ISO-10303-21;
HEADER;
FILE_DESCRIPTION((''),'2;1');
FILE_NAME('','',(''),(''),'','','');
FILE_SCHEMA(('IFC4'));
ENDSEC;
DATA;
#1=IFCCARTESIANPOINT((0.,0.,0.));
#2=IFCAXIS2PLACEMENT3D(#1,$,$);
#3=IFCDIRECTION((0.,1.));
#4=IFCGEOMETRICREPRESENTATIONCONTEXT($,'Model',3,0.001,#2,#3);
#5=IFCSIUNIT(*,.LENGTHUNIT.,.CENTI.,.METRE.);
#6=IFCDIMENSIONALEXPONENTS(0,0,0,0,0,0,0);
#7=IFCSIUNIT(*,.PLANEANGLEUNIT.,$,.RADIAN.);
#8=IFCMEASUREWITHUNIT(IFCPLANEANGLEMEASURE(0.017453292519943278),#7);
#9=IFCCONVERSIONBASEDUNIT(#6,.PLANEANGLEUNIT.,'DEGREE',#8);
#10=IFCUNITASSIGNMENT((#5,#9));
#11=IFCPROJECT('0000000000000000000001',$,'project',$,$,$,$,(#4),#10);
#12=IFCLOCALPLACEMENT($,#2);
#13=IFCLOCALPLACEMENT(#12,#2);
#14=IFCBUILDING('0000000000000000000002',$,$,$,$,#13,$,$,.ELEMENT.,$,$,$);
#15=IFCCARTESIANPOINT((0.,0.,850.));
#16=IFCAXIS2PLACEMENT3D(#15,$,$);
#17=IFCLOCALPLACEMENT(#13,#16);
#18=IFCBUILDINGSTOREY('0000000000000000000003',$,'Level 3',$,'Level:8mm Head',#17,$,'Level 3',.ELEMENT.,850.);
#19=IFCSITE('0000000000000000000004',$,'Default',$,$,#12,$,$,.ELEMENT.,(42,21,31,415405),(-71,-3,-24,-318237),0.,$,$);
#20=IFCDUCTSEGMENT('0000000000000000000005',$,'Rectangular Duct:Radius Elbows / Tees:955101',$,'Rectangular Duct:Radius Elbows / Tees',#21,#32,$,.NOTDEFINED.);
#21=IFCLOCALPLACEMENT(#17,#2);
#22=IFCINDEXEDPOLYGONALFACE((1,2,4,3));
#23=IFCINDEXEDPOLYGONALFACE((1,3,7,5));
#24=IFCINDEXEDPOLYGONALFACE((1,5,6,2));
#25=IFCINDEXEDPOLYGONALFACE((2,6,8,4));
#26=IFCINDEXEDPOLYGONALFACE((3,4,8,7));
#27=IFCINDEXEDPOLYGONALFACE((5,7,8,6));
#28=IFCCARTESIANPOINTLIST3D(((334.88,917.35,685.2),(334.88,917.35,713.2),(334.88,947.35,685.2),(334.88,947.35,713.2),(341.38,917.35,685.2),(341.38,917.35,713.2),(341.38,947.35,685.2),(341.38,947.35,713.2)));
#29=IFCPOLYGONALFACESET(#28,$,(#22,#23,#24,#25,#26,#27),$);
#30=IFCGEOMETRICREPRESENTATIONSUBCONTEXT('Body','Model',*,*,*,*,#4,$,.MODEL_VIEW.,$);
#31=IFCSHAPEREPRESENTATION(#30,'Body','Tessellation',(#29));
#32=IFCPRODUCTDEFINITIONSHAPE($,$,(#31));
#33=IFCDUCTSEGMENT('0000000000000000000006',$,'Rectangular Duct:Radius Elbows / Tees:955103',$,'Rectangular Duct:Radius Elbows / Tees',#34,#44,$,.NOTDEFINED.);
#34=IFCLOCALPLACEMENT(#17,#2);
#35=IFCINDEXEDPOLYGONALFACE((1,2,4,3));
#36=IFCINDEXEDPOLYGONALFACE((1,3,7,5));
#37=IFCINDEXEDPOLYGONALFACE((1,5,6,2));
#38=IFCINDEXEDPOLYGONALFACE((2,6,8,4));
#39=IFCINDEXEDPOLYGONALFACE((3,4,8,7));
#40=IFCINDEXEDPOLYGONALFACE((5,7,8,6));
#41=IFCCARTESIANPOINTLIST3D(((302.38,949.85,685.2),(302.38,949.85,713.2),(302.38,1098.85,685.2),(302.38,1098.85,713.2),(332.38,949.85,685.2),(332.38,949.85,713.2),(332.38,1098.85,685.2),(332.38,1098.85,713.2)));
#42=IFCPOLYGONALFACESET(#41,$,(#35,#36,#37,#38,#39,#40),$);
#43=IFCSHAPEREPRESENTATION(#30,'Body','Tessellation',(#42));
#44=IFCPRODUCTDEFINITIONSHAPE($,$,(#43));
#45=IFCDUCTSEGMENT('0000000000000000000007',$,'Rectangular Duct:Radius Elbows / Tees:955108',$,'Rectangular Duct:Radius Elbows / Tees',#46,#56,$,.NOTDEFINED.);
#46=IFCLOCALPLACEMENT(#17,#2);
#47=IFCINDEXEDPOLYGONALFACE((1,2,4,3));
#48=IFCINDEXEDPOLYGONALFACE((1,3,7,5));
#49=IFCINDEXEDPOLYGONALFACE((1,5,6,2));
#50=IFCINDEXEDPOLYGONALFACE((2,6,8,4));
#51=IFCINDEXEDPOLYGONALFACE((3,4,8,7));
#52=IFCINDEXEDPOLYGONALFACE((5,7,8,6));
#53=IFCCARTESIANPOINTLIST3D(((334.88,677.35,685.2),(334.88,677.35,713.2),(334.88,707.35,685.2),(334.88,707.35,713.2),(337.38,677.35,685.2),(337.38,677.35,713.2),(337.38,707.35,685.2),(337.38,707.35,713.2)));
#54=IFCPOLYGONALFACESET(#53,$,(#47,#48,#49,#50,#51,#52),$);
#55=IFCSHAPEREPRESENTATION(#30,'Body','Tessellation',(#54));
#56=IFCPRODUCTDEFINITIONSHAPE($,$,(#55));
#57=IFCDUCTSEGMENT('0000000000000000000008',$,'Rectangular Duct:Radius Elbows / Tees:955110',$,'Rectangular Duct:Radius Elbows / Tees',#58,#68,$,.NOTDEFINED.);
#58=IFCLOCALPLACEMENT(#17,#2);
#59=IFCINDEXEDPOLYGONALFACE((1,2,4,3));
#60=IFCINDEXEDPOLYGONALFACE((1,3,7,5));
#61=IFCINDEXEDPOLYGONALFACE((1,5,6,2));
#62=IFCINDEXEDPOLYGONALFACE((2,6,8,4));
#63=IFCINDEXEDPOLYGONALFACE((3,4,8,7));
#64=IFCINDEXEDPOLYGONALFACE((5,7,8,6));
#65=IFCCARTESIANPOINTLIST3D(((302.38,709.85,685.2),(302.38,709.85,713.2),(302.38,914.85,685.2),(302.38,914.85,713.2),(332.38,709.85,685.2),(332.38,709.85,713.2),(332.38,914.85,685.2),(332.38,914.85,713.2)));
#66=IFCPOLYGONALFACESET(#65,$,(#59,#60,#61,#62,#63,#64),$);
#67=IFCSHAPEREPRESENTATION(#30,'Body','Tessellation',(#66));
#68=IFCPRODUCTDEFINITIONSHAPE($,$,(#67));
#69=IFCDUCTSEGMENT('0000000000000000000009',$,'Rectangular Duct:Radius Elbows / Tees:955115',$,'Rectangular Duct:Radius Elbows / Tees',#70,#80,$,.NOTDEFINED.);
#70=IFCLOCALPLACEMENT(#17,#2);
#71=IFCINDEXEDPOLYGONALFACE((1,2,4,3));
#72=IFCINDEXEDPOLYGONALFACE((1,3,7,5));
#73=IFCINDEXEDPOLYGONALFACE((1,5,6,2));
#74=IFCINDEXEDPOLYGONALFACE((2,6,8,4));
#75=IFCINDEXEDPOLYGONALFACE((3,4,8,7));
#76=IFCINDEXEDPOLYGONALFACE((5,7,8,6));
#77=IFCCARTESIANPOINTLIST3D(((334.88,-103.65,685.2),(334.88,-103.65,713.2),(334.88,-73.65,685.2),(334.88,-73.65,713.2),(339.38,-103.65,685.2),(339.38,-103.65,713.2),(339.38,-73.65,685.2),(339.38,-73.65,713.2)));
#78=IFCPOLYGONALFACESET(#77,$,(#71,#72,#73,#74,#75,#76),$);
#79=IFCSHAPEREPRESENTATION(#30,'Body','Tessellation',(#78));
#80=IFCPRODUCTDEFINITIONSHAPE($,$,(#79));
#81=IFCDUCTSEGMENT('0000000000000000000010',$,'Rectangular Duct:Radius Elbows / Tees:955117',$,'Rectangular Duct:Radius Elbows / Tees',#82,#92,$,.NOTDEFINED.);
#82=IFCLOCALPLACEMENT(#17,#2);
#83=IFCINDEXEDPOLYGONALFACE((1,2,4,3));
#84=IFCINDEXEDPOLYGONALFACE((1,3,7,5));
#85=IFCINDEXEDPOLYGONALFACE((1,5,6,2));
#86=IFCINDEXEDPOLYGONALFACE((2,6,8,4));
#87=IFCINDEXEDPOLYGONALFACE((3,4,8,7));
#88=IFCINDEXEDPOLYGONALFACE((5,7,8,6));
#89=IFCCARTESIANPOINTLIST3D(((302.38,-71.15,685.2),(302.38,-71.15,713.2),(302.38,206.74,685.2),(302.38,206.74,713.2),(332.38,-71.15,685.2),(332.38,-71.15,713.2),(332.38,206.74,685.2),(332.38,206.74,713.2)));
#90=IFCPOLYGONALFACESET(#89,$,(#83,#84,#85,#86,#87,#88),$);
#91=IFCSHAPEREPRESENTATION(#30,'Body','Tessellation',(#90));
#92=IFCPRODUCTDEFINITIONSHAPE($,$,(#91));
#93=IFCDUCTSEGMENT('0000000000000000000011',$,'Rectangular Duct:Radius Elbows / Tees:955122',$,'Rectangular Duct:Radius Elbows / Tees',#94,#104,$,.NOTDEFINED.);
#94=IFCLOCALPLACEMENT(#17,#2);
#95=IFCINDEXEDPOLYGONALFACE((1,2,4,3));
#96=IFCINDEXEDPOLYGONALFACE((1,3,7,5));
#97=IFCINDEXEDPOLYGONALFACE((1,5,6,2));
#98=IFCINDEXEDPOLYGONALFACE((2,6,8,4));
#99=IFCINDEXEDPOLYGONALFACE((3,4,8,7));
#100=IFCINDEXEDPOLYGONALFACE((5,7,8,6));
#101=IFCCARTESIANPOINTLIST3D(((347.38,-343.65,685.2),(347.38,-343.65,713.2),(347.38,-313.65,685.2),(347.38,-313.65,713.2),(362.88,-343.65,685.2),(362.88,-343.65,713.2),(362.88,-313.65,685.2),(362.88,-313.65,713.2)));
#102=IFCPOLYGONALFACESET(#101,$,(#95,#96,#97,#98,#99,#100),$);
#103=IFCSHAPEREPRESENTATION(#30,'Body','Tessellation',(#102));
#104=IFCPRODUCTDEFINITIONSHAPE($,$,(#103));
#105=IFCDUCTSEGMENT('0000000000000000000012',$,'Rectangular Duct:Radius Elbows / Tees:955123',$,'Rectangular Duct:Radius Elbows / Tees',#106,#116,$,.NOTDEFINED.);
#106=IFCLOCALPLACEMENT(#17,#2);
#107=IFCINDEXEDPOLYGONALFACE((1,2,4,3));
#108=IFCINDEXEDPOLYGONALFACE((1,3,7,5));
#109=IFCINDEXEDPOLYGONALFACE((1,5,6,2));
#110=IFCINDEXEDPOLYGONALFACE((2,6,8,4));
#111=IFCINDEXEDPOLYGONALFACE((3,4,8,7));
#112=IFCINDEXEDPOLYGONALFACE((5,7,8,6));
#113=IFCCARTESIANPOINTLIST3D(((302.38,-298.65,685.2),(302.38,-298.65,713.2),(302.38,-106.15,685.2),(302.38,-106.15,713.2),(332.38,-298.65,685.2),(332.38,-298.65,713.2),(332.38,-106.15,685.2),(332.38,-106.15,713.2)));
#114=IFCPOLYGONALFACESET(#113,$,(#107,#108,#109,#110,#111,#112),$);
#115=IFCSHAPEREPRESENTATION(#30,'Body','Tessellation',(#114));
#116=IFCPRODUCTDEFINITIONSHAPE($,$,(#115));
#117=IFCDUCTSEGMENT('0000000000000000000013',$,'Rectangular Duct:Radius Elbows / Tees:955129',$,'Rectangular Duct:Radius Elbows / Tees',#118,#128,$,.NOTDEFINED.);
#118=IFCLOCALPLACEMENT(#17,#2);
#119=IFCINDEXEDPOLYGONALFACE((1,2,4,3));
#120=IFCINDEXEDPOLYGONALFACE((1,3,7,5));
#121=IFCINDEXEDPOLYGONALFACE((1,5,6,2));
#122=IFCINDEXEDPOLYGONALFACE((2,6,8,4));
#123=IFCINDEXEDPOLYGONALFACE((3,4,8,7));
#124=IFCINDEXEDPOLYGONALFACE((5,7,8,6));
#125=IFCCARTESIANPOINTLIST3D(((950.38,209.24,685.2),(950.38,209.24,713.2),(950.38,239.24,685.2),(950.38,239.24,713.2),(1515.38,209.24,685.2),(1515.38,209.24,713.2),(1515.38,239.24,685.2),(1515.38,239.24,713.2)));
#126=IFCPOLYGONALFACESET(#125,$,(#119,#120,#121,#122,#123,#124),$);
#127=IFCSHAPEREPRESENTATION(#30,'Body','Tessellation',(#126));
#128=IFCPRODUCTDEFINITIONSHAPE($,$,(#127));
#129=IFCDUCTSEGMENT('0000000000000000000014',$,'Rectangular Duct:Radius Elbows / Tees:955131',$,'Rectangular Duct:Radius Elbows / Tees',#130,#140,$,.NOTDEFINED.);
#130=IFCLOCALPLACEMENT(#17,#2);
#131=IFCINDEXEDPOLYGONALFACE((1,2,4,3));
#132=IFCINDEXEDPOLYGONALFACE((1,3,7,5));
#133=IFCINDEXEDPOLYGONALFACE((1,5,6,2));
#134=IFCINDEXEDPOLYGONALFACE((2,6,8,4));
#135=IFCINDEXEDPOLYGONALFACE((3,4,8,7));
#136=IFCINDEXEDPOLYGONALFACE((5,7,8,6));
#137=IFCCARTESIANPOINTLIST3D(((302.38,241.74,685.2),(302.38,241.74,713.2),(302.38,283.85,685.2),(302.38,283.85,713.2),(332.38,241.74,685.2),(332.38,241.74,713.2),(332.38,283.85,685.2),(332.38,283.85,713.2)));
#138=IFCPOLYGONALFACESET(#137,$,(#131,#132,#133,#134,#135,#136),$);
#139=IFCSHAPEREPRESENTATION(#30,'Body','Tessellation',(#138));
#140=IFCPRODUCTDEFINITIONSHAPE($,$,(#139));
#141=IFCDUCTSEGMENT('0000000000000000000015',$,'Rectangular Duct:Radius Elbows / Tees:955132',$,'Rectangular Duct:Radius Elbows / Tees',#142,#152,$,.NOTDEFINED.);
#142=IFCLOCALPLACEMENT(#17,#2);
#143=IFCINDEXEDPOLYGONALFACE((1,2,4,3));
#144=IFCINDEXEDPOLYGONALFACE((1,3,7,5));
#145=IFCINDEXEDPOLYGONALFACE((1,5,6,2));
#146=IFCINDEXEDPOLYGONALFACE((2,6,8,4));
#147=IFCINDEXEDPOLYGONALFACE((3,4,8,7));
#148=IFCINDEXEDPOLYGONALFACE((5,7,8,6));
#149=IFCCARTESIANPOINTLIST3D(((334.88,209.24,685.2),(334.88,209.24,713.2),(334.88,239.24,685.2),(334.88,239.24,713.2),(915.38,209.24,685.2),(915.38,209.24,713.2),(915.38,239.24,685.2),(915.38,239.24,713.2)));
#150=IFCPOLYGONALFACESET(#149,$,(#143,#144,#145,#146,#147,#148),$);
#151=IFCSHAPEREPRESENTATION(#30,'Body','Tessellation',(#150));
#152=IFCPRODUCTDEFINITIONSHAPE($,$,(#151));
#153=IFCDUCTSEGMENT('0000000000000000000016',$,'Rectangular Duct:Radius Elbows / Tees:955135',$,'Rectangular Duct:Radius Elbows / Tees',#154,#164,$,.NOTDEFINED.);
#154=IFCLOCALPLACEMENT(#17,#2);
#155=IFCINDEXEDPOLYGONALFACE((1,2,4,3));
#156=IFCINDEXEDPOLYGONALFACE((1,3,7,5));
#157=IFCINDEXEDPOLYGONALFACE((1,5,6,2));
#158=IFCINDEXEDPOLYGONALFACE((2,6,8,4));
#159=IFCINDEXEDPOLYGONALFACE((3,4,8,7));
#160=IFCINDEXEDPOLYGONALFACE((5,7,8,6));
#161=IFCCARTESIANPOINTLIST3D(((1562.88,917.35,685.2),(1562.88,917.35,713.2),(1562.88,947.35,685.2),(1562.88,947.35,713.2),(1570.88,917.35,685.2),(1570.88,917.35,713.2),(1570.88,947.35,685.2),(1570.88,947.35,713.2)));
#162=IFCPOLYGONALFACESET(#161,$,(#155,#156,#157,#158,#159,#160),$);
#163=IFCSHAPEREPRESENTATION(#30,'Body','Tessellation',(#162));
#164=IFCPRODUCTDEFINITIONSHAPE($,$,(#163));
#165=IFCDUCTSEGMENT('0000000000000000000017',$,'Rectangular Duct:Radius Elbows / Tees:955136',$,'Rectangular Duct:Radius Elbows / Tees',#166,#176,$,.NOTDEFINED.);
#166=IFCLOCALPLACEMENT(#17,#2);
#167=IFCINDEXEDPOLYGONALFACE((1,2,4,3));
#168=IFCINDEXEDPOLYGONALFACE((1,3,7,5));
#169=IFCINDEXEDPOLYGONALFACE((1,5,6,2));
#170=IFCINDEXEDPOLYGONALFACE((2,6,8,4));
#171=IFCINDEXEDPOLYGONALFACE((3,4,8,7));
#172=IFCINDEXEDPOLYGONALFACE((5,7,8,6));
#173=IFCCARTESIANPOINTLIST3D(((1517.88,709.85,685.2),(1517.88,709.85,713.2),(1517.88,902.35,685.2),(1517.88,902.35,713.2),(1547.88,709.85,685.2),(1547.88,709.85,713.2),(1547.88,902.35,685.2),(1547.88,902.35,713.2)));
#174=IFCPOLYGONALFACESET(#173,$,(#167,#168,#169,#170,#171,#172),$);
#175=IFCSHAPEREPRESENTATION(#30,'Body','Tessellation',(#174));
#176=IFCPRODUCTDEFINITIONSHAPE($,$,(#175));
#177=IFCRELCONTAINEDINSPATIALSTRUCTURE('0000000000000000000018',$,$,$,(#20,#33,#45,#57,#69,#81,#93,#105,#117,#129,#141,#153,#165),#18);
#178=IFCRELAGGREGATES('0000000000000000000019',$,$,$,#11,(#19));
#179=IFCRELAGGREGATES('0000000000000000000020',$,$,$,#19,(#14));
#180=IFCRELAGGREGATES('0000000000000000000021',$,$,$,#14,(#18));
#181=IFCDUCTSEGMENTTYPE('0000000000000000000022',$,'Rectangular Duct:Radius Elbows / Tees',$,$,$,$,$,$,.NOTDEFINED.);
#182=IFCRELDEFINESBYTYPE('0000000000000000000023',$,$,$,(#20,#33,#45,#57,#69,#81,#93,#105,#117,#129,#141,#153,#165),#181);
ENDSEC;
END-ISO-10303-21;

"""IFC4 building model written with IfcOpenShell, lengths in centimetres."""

from ifc_helpers import new_model, entity, si_unit, converted_unit, direction, frame, origin, place, context, subcontext, project, spatial, indexed_curve, outline, extrude, type_object, element, save


model = new_model("IFC4")

# Units and contexts
model_context = context("Model", 3, precision=0.001, world=origin(), true_north=direction((0.0, 1.0)))
body_context = subcontext(model_context, "Body", "Model", "MODEL_VIEW")
ifc_project = project(units=[si_unit("LENGTHUNIT", "METRE", prefix="CENTI"), converted_unit("PLANEANGLEUNIT", "DEGREE", entity("IfcPlaneAngleMeasure", 0.017453292519943278), si_unit("PLANEANGLEUNIT", "RADIAN"), dimensions=[0, 0, 0, 0, 0, 0, 0])], contexts=[model_context])

# Site, building, storey
site_placement = place(None, origin())
site = spatial("IfcSite", under=ifc_project, at=site_placement, Name="Default", CompositionType="ELEMENT", RefLatitude=(42, 21, 31, 415405), RefLongitude=(-71, -3, -24, -318237), RefElevation=0.0)
building_placement = place(site_placement, origin())
building = spatial("IfcBuilding", under=site, at=building_placement, CompositionType="ELEMENT")
storey_placement = place(building_placement, frame((0.0, 0.0, 850.0)))
storey = spatial("IfcBuildingStorey", under=building, at=storey_placement, Name="Level 3", ObjectType="Level:8mm Head", LongName="Level 3", CompositionType="ELEMENT", Elevation=850.0)

# Duct segments
duct_segment_type_1 = type_object("IfcDuctSegmentType", Name="Rectangular Duct:Radius Elbows / Tees", PredefinedType="NOTDEFINED")
duct_segment_1_placement = place(storey_placement, origin())
element("IfcDuctSegment", 1, at=duct_segment_1_placement, inside=storey, type_object=duct_segment_type_1, Name="Rectangular Duct:Radius Elbows / Tees:955101", ObjectType="Rectangular Duct:Radius Elbows / Tees", PredefinedType="NOTDEFINED", context=body_context, shape_type="SweptSolid", body=[
    extrude(outline(indexed_curve([(-3.25, -15.0), (3.25, -15.0), (3.25, 15.0), (-3.25, 15.0), (-3.25, -15.0)], self_intersect=False)), frame((338.13, 932.35, 685.2)), (0.0, 0.0, 1.0), 28.0),
])
duct_segment_2_placement = place(storey_placement, origin())
element("IfcDuctSegment", 2, at=duct_segment_2_placement, inside=storey, type_object=duct_segment_type_1, Name="Rectangular Duct:Radius Elbows / Tees:955103", ObjectType="Rectangular Duct:Radius Elbows / Tees", PredefinedType="NOTDEFINED", context=body_context, shape_type="SweptSolid", body=[
    extrude(outline(indexed_curve([(-74.5, -15.0), (74.5, -15.0), (74.5, 15.0), (-74.5, 15.0), (-74.5, -15.0)], self_intersect=False)), frame((317.38, 1024.35, 685.2), z_axis=(0.0, 0.0, 1.0), x_axis=(0.0, -1.0, 0.0)), (0.0, 0.0, 1.0), 28.0),
])
duct_segment_3_placement = place(storey_placement, origin())
element("IfcDuctSegment", 3, at=duct_segment_3_placement, inside=storey, type_object=duct_segment_type_1, Name="Rectangular Duct:Radius Elbows / Tees:955108", ObjectType="Rectangular Duct:Radius Elbows / Tees", PredefinedType="NOTDEFINED", context=body_context, shape_type="SweptSolid", body=[
    extrude(outline(indexed_curve([(-1.25, -15.0), (1.25, -15.0), (1.25, 15.0), (-1.25, 15.0), (-1.25, -15.0)], self_intersect=False)), frame((336.13, 692.35, 685.2)), (0.0, 0.0, 1.0), 28.0),
])
duct_segment_4_placement = place(storey_placement, origin())
element("IfcDuctSegment", 4, at=duct_segment_4_placement, inside=storey, type_object=duct_segment_type_1, Name="Rectangular Duct:Radius Elbows / Tees:955110", ObjectType="Rectangular Duct:Radius Elbows / Tees", PredefinedType="NOTDEFINED", context=body_context, shape_type="SweptSolid", body=[
    extrude(outline(indexed_curve([(-102.5, -15.0), (102.5, -15.0), (102.5, 15.0), (-102.5, 15.0), (-102.5, -15.0)], self_intersect=False)), frame((317.38, 812.35, 685.2), z_axis=(0.0, 0.0, 1.0), x_axis=(0.0, -1.0, 0.0)), (0.0, 0.0, 1.0), 28.0),
])
duct_segment_5_placement = place(storey_placement, origin())
element("IfcDuctSegment", 5, at=duct_segment_5_placement, inside=storey, type_object=duct_segment_type_1, Name="Rectangular Duct:Radius Elbows / Tees:955115", ObjectType="Rectangular Duct:Radius Elbows / Tees", PredefinedType="NOTDEFINED", context=body_context, shape_type="SweptSolid", body=[
    extrude(outline(indexed_curve([(-2.25, -15.0), (2.25, -15.0), (2.25, 15.0), (-2.25, 15.0), (-2.25, -15.0)], self_intersect=False)), frame((337.13, -88.65, 685.2)), (0.0, 0.0, 1.0), 28.0),
])
duct_segment_6_placement = place(storey_placement, origin())
element("IfcDuctSegment", 6, at=duct_segment_6_placement, inside=storey, type_object=duct_segment_type_1, Name="Rectangular Duct:Radius Elbows / Tees:955117", ObjectType="Rectangular Duct:Radius Elbows / Tees", PredefinedType="NOTDEFINED", context=body_context, shape_type="SweptSolid", body=[
    extrude(outline(indexed_curve([(-138.95, -15.0), (138.95, -15.0), (138.95, 15.0), (-138.95, 15.0), (-138.95, -15.0)], self_intersect=False)), frame((317.38, 67.79, 685.2), z_axis=(0.0, 0.0, 1.0), x_axis=(0.0, -1.0, 0.0)), (0.0, 0.0, 1.0), 28.0),
])
duct_segment_7_placement = place(storey_placement, origin())
element("IfcDuctSegment", 7, at=duct_segment_7_placement, inside=storey, type_object=duct_segment_type_1, Name="Rectangular Duct:Radius Elbows / Tees:955122", ObjectType="Rectangular Duct:Radius Elbows / Tees", PredefinedType="NOTDEFINED", context=body_context, shape_type="SweptSolid", body=[
    extrude(outline(indexed_curve([(-7.75, -15.0), (7.75, -15.0), (7.75, 15.0), (-7.75, 15.0), (-7.75, -15.0)], self_intersect=False)), frame((355.13, -328.65, 685.2)), (0.0, 0.0, 1.0), 28.0),
])
duct_segment_8_placement = place(storey_placement, origin())
element("IfcDuctSegment", 8, at=duct_segment_8_placement, inside=storey, type_object=duct_segment_type_1, Name="Rectangular Duct:Radius Elbows / Tees:955123", ObjectType="Rectangular Duct:Radius Elbows / Tees", PredefinedType="NOTDEFINED", context=body_context, shape_type="SweptSolid", body=[
    extrude(outline(indexed_curve([(-96.25, -15.0), (96.25, -15.0), (96.25, 15.0), (-96.25, 15.0), (-96.25, -15.0)], self_intersect=False)), frame((317.38, -202.4, 685.2), z_axis=(0.0, 0.0, 1.0), x_axis=(0.0, -1.0, 0.0)), (0.0, 0.0, 1.0), 28.0),
])
duct_segment_9_placement = place(storey_placement, origin())
element("IfcDuctSegment", 9, at=duct_segment_9_placement, inside=storey, type_object=duct_segment_type_1, Name="Rectangular Duct:Radius Elbows / Tees:955129", ObjectType="Rectangular Duct:Radius Elbows / Tees", PredefinedType="NOTDEFINED", context=body_context, shape_type="SweptSolid", body=[
    extrude(outline(indexed_curve([(-282.5, -15.0), (282.5, -15.0), (282.5, 15.0), (-282.5, 15.0), (-282.5, -15.0)], self_intersect=False)), frame((1232.88, 224.24, 685.2)), (0.0, 0.0, 1.0), 28.0),
])
duct_segment_10_placement = place(storey_placement, origin())
element("IfcDuctSegment", 10, at=duct_segment_10_placement, inside=storey, type_object=duct_segment_type_1, Name="Rectangular Duct:Radius Elbows / Tees:955131", ObjectType="Rectangular Duct:Radius Elbows / Tees", PredefinedType="NOTDEFINED", context=body_context, shape_type="SweptSolid", body=[
    extrude(outline(indexed_curve([(-21.05, -15.0), (21.05, -15.0), (21.05, 15.0), (-21.05, 15.0), (-21.05, -15.0)], self_intersect=False)), frame((317.38, 262.79, 685.2), z_axis=(0.0, 0.0, 1.0), x_axis=(0.0, -1.0, 0.0)), (0.0, 0.0, 1.0), 28.0),
])
duct_segment_11_placement = place(storey_placement, origin())
element("IfcDuctSegment", 11, at=duct_segment_11_placement, inside=storey, type_object=duct_segment_type_1, Name="Rectangular Duct:Radius Elbows / Tees:955132", ObjectType="Rectangular Duct:Radius Elbows / Tees", PredefinedType="NOTDEFINED", context=body_context, shape_type="SweptSolid", body=[
    extrude(outline(indexed_curve([(-290.25, -15.0), (290.25, -15.0), (290.25, 15.0), (-290.25, 15.0), (-290.25, -15.0)], self_intersect=False)), frame((625.13, 224.24, 685.2)), (0.0, 0.0, 1.0), 28.0),
])
duct_segment_12_placement = place(storey_placement, origin())
element("IfcDuctSegment", 12, at=duct_segment_12_placement, inside=storey, type_object=duct_segment_type_1, Name="Rectangular Duct:Radius Elbows / Tees:955135", ObjectType="Rectangular Duct:Radius Elbows / Tees", PredefinedType="NOTDEFINED", context=body_context, shape_type="SweptSolid", body=[
    extrude(outline(indexed_curve([(-4.0, -15.0), (4.0, -15.0), (4.0, 15.0), (-4.0, 15.0), (-4.0, -15.0)], self_intersect=False)), frame((1566.88, 932.35, 685.2)), (0.0, 0.0, 1.0), 28.0),
])
duct_segment_13_placement = place(storey_placement, origin())
element("IfcDuctSegment", 13, at=duct_segment_13_placement, inside=storey, type_object=duct_segment_type_1, Name="Rectangular Duct:Radius Elbows / Tees:955136", ObjectType="Rectangular Duct:Radius Elbows / Tees", PredefinedType="NOTDEFINED", context=body_context, shape_type="SweptSolid", body=[
    extrude(outline(indexed_curve([(-96.25, -15.0), (96.25, -15.0), (96.25, 15.0), (-96.25, 15.0), (-96.25, -15.0)], self_intersect=False)), frame((1532.88, 806.1, 685.2), z_axis=(0.0, 0.0, 1.0), x_axis=(0.0, 1.0, 0.0)), (0.0, 0.0, 1.0), 28.0),
])

save(model, "model.ifc")
